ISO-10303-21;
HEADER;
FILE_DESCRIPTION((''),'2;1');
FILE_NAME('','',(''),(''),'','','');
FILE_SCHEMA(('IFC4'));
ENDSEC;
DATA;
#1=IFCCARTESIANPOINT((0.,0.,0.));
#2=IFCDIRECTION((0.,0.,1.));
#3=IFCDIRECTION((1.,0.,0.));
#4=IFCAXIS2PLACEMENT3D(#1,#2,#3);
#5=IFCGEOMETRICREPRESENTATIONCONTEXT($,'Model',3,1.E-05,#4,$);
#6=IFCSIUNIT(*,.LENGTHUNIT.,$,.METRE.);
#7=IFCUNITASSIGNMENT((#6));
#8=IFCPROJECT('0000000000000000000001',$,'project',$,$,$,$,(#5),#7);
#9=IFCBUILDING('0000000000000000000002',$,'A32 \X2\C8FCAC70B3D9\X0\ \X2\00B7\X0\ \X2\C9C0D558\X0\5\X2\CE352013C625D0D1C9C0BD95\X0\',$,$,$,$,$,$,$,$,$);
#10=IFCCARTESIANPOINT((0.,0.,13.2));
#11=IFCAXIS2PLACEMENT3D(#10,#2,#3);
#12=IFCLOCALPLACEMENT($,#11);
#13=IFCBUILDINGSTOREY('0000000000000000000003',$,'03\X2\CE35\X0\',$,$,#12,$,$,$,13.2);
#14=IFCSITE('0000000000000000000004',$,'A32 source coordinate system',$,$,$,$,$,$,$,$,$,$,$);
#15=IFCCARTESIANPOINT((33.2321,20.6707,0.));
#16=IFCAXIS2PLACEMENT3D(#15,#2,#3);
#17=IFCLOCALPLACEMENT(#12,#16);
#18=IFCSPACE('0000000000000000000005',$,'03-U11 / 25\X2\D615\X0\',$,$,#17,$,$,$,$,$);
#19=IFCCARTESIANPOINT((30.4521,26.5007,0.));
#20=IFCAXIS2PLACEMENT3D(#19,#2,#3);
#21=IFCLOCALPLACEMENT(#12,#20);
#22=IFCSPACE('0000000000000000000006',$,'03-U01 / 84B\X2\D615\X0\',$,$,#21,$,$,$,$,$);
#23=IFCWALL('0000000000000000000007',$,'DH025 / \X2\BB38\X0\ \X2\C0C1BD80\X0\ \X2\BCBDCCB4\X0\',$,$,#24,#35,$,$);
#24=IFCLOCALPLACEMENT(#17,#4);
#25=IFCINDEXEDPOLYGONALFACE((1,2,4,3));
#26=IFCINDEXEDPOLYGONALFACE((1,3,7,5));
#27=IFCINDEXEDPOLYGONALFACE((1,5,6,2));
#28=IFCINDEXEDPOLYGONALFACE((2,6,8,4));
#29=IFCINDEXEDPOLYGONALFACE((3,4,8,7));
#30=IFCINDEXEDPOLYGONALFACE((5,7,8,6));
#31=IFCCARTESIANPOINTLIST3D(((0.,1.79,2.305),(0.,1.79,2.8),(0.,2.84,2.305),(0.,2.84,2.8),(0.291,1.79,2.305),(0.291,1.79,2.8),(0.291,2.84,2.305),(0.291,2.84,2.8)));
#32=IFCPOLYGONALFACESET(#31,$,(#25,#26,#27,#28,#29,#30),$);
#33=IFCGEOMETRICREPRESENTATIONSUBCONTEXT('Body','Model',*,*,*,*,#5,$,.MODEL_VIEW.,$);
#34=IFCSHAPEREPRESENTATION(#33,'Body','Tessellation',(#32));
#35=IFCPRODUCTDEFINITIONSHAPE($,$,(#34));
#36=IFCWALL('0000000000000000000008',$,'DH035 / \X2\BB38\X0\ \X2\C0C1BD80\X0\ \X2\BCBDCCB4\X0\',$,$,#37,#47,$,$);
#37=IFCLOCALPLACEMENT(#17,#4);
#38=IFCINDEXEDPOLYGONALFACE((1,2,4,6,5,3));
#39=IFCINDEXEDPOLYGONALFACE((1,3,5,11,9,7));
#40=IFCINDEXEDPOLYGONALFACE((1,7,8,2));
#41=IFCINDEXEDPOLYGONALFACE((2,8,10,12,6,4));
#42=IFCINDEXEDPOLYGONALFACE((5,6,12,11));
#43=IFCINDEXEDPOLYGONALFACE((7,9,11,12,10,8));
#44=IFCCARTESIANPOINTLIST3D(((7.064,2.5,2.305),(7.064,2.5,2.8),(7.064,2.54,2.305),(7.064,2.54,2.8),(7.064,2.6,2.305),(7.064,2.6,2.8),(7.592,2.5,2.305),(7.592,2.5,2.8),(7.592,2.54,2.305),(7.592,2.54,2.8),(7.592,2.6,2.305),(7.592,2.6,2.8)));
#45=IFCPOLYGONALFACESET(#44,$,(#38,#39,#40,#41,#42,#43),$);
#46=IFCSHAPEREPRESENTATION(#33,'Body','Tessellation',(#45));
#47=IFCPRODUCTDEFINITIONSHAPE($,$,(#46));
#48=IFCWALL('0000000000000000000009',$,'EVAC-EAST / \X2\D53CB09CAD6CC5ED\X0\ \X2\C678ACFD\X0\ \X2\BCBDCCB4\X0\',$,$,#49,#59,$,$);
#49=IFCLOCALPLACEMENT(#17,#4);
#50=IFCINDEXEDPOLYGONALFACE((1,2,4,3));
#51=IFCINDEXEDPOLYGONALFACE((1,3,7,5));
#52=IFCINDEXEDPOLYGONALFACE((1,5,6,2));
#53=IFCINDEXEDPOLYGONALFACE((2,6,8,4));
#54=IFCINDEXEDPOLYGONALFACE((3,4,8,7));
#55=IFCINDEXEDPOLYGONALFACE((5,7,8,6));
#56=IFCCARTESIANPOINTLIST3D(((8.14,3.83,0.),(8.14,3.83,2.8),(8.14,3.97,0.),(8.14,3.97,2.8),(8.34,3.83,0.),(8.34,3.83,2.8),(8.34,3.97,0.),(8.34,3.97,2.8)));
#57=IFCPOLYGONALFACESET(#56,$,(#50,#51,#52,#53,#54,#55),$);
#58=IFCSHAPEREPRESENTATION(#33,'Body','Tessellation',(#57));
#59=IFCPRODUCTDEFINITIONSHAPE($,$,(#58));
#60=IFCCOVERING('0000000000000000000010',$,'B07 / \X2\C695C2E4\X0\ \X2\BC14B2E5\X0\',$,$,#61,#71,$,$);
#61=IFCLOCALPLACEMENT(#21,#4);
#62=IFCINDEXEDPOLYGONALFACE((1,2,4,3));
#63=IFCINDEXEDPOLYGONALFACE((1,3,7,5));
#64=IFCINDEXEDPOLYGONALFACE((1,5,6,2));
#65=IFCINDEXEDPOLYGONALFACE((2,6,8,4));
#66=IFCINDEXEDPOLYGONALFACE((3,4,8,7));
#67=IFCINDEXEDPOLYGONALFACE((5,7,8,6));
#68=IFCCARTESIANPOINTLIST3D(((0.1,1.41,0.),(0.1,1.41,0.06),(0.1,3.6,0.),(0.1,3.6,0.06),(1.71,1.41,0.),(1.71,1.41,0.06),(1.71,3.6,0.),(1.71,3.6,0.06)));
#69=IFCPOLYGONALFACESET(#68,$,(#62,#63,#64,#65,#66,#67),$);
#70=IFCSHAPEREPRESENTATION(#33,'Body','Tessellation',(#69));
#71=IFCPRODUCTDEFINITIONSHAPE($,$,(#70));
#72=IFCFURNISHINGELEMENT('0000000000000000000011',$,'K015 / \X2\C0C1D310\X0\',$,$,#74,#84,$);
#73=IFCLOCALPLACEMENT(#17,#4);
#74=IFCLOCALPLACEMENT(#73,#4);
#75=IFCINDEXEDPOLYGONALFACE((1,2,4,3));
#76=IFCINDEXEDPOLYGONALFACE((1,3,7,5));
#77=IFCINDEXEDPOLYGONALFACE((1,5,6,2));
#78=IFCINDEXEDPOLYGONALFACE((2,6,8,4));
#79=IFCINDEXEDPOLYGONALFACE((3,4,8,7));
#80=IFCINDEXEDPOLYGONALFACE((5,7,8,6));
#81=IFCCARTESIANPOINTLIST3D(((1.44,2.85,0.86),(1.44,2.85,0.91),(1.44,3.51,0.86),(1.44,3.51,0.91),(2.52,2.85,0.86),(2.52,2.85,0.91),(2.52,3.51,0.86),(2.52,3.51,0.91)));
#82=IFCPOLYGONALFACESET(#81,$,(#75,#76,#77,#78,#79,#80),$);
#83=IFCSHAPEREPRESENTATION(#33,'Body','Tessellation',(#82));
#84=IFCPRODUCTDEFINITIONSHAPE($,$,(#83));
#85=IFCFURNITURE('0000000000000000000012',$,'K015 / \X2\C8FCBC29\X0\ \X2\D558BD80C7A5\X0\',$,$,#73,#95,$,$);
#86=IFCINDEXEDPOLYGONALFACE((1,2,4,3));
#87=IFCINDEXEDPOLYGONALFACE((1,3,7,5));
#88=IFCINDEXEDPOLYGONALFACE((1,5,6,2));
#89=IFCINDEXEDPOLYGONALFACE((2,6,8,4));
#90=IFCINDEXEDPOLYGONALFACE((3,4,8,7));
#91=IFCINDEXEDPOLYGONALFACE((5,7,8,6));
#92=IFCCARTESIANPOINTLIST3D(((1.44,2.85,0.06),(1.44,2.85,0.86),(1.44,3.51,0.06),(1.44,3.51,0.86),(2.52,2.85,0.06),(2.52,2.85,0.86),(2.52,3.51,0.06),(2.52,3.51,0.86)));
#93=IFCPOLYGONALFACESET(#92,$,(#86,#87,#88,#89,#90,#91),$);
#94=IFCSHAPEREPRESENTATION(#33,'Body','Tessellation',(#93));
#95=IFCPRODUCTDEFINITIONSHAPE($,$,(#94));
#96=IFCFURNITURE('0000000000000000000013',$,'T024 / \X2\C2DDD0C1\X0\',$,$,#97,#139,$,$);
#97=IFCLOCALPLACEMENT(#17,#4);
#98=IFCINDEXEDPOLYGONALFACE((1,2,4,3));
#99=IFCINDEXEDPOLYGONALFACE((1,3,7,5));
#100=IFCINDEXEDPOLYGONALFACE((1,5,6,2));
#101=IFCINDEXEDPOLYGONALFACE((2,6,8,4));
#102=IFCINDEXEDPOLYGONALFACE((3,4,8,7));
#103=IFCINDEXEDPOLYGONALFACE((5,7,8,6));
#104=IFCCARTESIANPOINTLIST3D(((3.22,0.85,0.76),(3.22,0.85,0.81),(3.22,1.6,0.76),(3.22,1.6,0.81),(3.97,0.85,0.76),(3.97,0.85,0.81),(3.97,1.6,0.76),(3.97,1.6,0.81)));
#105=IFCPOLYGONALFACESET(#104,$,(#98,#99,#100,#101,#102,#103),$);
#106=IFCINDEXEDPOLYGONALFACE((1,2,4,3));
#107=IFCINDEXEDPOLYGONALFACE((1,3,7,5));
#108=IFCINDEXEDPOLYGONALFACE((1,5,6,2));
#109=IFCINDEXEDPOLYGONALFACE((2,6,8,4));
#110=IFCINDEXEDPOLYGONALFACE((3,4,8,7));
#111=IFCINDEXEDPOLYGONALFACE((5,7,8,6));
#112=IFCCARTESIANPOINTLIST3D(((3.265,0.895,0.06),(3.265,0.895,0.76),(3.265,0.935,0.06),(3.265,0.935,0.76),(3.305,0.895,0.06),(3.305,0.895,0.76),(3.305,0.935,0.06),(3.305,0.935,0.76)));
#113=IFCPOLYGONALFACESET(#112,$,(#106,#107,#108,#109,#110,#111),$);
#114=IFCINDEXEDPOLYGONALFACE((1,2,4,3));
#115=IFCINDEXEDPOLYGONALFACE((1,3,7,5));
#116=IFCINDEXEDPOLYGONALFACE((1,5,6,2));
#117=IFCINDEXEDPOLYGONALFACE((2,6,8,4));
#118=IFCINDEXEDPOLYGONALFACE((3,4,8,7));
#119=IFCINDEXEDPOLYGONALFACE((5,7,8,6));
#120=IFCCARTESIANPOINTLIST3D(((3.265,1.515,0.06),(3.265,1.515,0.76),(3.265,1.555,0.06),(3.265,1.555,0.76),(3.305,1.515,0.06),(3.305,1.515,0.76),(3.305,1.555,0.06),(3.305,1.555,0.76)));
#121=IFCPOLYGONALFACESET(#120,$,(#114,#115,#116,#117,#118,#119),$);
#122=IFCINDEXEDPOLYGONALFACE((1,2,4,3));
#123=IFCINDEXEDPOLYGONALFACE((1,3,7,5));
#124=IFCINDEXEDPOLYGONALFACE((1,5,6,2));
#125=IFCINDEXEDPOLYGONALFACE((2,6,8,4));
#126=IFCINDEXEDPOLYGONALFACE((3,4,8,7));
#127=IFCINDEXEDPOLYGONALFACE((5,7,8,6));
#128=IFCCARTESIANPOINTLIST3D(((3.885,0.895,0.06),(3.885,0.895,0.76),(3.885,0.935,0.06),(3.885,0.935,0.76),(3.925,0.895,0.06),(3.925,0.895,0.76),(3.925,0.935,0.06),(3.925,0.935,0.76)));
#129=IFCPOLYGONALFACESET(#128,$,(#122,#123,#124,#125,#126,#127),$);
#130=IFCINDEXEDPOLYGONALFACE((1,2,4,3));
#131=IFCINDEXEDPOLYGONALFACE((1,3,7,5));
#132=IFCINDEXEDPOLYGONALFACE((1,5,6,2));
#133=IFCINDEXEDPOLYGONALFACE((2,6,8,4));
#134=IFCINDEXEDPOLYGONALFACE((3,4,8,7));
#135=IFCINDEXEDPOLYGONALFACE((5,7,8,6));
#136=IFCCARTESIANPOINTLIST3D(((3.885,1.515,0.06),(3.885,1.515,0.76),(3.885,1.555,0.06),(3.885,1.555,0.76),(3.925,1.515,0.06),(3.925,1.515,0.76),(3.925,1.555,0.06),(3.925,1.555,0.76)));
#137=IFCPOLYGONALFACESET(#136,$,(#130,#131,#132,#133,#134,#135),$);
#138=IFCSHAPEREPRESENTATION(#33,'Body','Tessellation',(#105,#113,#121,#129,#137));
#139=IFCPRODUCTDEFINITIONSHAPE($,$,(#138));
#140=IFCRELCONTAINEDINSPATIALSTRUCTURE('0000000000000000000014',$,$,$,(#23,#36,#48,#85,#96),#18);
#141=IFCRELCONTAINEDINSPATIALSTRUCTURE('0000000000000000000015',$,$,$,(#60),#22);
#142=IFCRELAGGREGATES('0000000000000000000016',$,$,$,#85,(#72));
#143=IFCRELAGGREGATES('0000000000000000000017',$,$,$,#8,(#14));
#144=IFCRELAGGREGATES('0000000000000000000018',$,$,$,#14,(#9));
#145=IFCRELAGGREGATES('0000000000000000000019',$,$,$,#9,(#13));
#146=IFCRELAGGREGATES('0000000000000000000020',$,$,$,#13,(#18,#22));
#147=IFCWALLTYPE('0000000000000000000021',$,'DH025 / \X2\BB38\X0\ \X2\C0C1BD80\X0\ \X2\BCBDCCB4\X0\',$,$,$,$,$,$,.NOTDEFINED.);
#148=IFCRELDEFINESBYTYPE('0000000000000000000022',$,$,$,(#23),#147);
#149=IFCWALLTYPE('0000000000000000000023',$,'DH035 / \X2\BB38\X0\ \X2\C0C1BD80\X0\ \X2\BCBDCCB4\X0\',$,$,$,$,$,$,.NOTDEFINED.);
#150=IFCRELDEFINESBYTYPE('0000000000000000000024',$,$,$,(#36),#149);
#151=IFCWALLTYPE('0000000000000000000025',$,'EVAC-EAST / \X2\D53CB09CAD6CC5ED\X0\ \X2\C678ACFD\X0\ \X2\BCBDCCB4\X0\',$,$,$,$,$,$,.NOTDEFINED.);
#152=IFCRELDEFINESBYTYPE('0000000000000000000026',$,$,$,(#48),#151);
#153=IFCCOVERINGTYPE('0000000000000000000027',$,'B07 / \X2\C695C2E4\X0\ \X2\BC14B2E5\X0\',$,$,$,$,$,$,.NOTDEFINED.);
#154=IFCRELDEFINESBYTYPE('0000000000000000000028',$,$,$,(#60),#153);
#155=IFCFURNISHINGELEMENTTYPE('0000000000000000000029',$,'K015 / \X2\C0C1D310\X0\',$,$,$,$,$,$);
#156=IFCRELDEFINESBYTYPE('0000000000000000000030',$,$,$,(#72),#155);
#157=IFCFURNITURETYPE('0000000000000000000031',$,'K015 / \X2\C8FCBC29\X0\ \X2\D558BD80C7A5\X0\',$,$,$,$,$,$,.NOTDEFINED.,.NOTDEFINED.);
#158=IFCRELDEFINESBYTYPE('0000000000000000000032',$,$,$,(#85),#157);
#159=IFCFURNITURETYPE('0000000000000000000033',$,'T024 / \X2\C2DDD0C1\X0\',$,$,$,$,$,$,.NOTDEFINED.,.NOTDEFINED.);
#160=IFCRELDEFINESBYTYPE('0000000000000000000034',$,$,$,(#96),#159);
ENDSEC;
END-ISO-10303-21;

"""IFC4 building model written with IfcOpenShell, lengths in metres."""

from ifc_helpers import new_model, si_unit, frame, origin, origin_with_axes, place, context, subcontext, project, spatial, polyline, outline, extrude, source, transform, mapped, type_object, type_shapes, element, aggregate, save


model = new_model("IFC4")

# Units and contexts
model_context = context("Model", 3, precision=1e-05, world=origin_with_axes())
body_context = subcontext(model_context, "Body", "Model", "MODEL_VIEW")
ifc_project = project(units=[si_unit("LENGTHUNIT", "METRE")], contexts=[model_context])

# Site, building, storey, space
site = spatial("IfcSite", under=ifc_project, Name="A32 source coordinate system")
building = spatial("IfcBuilding", under=site, Name="A32 주거동 · 지하5층–옥탑지붕")
storey_placement = place(None, frame((0.0, 0.0, 13.2), z_axis=(0.0, 0.0, 1.0), x_axis=(1.0, 0.0, 0.0)))
storey = spatial("IfcBuildingStorey", under=building, at=storey_placement, Name="03층", Elevation=13.2)
space_1_placement = place(storey_placement, frame((33.2321, 20.6707, 0.0), z_axis=(0.0, 0.0, 1.0), x_axis=(1.0, 0.0, 0.0)))
space_1 = spatial("IfcSpace", under=storey, at=space_1_placement, Name="03-U11 / 25형")

# Walls
wall_type_1 = type_object("IfcWallType", Name="DH025 / 문 상부 벽체", PredefinedType="NOTDEFINED")
shared_shape_1 = source(origin(), body_context, "Body", "SweptSolid", [
    extrude(outline(polyline([(0.0, 1.79), (0.0, 2.84), (0.291, 2.84), (0.291, 1.79), (0.0, 1.79)])), frame((0.0, 0.0, 2.305)), (0.0, 0.0, 1.0), 0.495),
])
type_shapes(wall_type_1, [shared_shape_1])
wall_1_placement = place(space_1_placement, origin_with_axes())
element("IfcWall", 1, at=wall_1_placement, inside=space_1, type_object=wall_type_1, Name="DH025 / 문 상부 벽체", context=body_context, shape_type="MappedRepresentation", body=[
    mapped(shared_shape_1, transform((0.0, 0.0, 0.0), scale=1.0)),
])
wall_type_2 = type_object("IfcWallType", Name="DH035 / 문 상부 벽체", PredefinedType="NOTDEFINED")
shared_shape_2 = source(origin(), body_context, "Body", "SweptSolid", [
    extrude(outline(polyline([(7.592, 2.6), (7.592, 2.54), (7.592, 2.5), (7.064, 2.5), (7.064, 2.54), (7.064, 2.6), (7.592, 2.6)])), frame((0.0, 0.0, 2.305)), (0.0, 0.0, 1.0), 0.495),
])
type_shapes(wall_type_2, [shared_shape_2])
wall_2_placement = place(space_1_placement, origin_with_axes())
element("IfcWall", 2, at=wall_2_placement, inside=space_1, type_object=wall_type_2, Name="DH035 / 문 상부 벽체", context=body_context, shape_type="MappedRepresentation", body=[
    mapped(shared_shape_2, transform((0.0, 0.0, 0.0), scale=1.0)),
])
wall_type_3 = type_object("IfcWallType", Name="EVAC-EAST / 피난구역 외곽 벽체", PredefinedType="NOTDEFINED")
shared_shape_3 = source(origin(), body_context, "Body", "SweptSolid", [
    extrude(outline(polyline([(8.34, 3.83), (8.14, 3.83), (8.14, 3.97), (8.34, 3.97), (8.34, 3.83)])), origin(), (0.0, 0.0, 1.0), 2.8),
])
type_shapes(wall_type_3, [shared_shape_3])
wall_3_placement = place(space_1_placement, origin_with_axes())
element("IfcWall", 3, at=wall_3_placement, inside=space_1, type_object=wall_type_3, Name="EVAC-EAST / 피난구역 외곽 벽체", context=body_context, shape_type="MappedRepresentation", body=[
    mapped(shared_shape_3, transform((0.0, 0.0, 0.0), scale=1.0)),
])

# Shared definitions
space_2_placement = place(storey_placement, frame((30.4521, 26.5007, 0.0), z_axis=(0.0, 0.0, 1.0), x_axis=(1.0, 0.0, 0.0)))
space_2 = spatial("IfcSpace", under=storey, at=space_2_placement, Name="03-U01 / 84B형")

# Covering
covering_type_1 = type_object("IfcCoveringType", Name="B07 / 욕실 바닥", PredefinedType="NOTDEFINED")
shared_shape_4 = source(origin(), body_context, "Body", "SweptSolid", [
    extrude(outline(polyline([(1.71, 1.41), (0.1, 1.41), (0.1, 3.6), (1.71, 3.6), (1.71, 1.41)])), origin(), (0.0, 0.0, 1.0), 0.06),
])
type_shapes(covering_type_1, [shared_shape_4])
covering_1_placement = place(space_2_placement, origin_with_axes())
element("IfcCovering", 4, at=covering_1_placement, inside=space_2, type_object=covering_type_1, Name="B07 / 욕실 바닥", context=body_context, shape_type="MappedRepresentation", body=[
    mapped(shared_shape_4, transform((0.0, 0.0, 0.0), scale=1.0)),
])

# Furnishing element
furnishing_element_type_1 = type_object("IfcFurnishingElementType", Name="K015 / 상판")
shared_shape_5 = source(origin(), body_context, "Body", "SweptSolid", [
    extrude(outline(polyline([(2.52, 2.85), (1.44, 2.85), (1.44, 3.51), (2.52, 3.51), (2.52, 2.85)])), frame((0.0, 0.0, 0.86)), (0.0, 0.0, 1.0), 0.05),
])
type_shapes(furnishing_element_type_1, [shared_shape_5])
furniture_1_placement = place(space_1_placement, origin_with_axes())
furnishing_1_placement = place(furniture_1_placement, origin_with_axes())
furnishing_1 = element("IfcFurnishingElement", 5, at=furnishing_1_placement, type_object=furnishing_element_type_1, Name="K015 / 상판", context=body_context, shape_type="MappedRepresentation", body=[
    mapped(shared_shape_5, transform((0.0, 0.0, 0.0), scale=1.0)),
])

# Furniture
furniture_type_1 = type_object("IfcFurnitureType", Name="K015 / 주방 하부장", AssemblyPlace="NOTDEFINED", PredefinedType="NOTDEFINED")
shared_shape_6 = source(origin(), body_context, "Body", "SweptSolid", [
    extrude(outline(polyline([(2.52, 3.51), (2.52, 2.85), (1.44, 2.85), (1.44, 3.51), (2.52, 3.51)])), frame((0.0, 0.0, 0.06)), (0.0, 0.0, 1.0), 0.8),
])
type_shapes(furniture_type_1, [shared_shape_6])
furniture_1 = element("IfcFurniture", 6, at=furniture_1_placement, inside=space_1, type_object=furniture_type_1, Name="K015 / 주방 하부장", context=body_context, shape_type="MappedRepresentation", body=[
    mapped(shared_shape_6, transform((0.0, 0.0, 0.0), scale=1.0)),
])
aggregate(furniture_1, [furnishing_1])
furniture_type_2 = type_object("IfcFurnitureType", Name="T024 / 식탁", AssemblyPlace="NOTDEFINED", PredefinedType="NOTDEFINED")
shared_shape_7 = source(origin(), body_context, "Body", "SweptSolid", [
    extrude(outline(polyline([(3.22, 0.85), (3.22, 1.6), (3.97, 1.6), (3.97, 0.85), (3.22, 0.85)])), frame((0.0, 0.0, 0.76)), (0.0, 0.0, 1.0), 0.05),
    extrude(outline(polyline([(3.265, 0.895), (3.265, 0.935), (3.305, 0.935), (3.305, 0.895), (3.265, 0.895)])), frame((0.0, 0.0, 0.06)), (0.0, 0.0, 1.0), 0.7),
    extrude(outline(polyline([(3.265, 1.515), (3.265, 1.555), (3.305, 1.555), (3.305, 1.515), (3.265, 1.515)])), frame((0.0, 0.0, 0.06)), (0.0, 0.0, 1.0), 0.7),
    extrude(outline(polyline([(3.885, 0.895), (3.885, 0.935), (3.925, 0.935), (3.925, 0.895), (3.885, 0.895)])), frame((0.0, 0.0, 0.06)), (0.0, 0.0, 1.0), 0.7),
    extrude(outline(polyline([(3.885, 1.515), (3.885, 1.555), (3.925, 1.555), (3.925, 1.515), (3.885, 1.515)])), frame((0.0, 0.0, 0.06)), (0.0, 0.0, 1.0), 0.7),
])
type_shapes(furniture_type_2, [shared_shape_7])
furniture_2_placement = place(space_1_placement, origin_with_axes())
element("IfcFurniture", 7, at=furniture_2_placement, inside=space_1, type_object=furniture_type_2, Name="T024 / 식탁", context=body_context, shape_type="MappedRepresentation", body=[
    mapped(shared_shape_7, transform((0.0, 0.0, 0.0), scale=1.0)),
])

save(model, "model.ifc")
